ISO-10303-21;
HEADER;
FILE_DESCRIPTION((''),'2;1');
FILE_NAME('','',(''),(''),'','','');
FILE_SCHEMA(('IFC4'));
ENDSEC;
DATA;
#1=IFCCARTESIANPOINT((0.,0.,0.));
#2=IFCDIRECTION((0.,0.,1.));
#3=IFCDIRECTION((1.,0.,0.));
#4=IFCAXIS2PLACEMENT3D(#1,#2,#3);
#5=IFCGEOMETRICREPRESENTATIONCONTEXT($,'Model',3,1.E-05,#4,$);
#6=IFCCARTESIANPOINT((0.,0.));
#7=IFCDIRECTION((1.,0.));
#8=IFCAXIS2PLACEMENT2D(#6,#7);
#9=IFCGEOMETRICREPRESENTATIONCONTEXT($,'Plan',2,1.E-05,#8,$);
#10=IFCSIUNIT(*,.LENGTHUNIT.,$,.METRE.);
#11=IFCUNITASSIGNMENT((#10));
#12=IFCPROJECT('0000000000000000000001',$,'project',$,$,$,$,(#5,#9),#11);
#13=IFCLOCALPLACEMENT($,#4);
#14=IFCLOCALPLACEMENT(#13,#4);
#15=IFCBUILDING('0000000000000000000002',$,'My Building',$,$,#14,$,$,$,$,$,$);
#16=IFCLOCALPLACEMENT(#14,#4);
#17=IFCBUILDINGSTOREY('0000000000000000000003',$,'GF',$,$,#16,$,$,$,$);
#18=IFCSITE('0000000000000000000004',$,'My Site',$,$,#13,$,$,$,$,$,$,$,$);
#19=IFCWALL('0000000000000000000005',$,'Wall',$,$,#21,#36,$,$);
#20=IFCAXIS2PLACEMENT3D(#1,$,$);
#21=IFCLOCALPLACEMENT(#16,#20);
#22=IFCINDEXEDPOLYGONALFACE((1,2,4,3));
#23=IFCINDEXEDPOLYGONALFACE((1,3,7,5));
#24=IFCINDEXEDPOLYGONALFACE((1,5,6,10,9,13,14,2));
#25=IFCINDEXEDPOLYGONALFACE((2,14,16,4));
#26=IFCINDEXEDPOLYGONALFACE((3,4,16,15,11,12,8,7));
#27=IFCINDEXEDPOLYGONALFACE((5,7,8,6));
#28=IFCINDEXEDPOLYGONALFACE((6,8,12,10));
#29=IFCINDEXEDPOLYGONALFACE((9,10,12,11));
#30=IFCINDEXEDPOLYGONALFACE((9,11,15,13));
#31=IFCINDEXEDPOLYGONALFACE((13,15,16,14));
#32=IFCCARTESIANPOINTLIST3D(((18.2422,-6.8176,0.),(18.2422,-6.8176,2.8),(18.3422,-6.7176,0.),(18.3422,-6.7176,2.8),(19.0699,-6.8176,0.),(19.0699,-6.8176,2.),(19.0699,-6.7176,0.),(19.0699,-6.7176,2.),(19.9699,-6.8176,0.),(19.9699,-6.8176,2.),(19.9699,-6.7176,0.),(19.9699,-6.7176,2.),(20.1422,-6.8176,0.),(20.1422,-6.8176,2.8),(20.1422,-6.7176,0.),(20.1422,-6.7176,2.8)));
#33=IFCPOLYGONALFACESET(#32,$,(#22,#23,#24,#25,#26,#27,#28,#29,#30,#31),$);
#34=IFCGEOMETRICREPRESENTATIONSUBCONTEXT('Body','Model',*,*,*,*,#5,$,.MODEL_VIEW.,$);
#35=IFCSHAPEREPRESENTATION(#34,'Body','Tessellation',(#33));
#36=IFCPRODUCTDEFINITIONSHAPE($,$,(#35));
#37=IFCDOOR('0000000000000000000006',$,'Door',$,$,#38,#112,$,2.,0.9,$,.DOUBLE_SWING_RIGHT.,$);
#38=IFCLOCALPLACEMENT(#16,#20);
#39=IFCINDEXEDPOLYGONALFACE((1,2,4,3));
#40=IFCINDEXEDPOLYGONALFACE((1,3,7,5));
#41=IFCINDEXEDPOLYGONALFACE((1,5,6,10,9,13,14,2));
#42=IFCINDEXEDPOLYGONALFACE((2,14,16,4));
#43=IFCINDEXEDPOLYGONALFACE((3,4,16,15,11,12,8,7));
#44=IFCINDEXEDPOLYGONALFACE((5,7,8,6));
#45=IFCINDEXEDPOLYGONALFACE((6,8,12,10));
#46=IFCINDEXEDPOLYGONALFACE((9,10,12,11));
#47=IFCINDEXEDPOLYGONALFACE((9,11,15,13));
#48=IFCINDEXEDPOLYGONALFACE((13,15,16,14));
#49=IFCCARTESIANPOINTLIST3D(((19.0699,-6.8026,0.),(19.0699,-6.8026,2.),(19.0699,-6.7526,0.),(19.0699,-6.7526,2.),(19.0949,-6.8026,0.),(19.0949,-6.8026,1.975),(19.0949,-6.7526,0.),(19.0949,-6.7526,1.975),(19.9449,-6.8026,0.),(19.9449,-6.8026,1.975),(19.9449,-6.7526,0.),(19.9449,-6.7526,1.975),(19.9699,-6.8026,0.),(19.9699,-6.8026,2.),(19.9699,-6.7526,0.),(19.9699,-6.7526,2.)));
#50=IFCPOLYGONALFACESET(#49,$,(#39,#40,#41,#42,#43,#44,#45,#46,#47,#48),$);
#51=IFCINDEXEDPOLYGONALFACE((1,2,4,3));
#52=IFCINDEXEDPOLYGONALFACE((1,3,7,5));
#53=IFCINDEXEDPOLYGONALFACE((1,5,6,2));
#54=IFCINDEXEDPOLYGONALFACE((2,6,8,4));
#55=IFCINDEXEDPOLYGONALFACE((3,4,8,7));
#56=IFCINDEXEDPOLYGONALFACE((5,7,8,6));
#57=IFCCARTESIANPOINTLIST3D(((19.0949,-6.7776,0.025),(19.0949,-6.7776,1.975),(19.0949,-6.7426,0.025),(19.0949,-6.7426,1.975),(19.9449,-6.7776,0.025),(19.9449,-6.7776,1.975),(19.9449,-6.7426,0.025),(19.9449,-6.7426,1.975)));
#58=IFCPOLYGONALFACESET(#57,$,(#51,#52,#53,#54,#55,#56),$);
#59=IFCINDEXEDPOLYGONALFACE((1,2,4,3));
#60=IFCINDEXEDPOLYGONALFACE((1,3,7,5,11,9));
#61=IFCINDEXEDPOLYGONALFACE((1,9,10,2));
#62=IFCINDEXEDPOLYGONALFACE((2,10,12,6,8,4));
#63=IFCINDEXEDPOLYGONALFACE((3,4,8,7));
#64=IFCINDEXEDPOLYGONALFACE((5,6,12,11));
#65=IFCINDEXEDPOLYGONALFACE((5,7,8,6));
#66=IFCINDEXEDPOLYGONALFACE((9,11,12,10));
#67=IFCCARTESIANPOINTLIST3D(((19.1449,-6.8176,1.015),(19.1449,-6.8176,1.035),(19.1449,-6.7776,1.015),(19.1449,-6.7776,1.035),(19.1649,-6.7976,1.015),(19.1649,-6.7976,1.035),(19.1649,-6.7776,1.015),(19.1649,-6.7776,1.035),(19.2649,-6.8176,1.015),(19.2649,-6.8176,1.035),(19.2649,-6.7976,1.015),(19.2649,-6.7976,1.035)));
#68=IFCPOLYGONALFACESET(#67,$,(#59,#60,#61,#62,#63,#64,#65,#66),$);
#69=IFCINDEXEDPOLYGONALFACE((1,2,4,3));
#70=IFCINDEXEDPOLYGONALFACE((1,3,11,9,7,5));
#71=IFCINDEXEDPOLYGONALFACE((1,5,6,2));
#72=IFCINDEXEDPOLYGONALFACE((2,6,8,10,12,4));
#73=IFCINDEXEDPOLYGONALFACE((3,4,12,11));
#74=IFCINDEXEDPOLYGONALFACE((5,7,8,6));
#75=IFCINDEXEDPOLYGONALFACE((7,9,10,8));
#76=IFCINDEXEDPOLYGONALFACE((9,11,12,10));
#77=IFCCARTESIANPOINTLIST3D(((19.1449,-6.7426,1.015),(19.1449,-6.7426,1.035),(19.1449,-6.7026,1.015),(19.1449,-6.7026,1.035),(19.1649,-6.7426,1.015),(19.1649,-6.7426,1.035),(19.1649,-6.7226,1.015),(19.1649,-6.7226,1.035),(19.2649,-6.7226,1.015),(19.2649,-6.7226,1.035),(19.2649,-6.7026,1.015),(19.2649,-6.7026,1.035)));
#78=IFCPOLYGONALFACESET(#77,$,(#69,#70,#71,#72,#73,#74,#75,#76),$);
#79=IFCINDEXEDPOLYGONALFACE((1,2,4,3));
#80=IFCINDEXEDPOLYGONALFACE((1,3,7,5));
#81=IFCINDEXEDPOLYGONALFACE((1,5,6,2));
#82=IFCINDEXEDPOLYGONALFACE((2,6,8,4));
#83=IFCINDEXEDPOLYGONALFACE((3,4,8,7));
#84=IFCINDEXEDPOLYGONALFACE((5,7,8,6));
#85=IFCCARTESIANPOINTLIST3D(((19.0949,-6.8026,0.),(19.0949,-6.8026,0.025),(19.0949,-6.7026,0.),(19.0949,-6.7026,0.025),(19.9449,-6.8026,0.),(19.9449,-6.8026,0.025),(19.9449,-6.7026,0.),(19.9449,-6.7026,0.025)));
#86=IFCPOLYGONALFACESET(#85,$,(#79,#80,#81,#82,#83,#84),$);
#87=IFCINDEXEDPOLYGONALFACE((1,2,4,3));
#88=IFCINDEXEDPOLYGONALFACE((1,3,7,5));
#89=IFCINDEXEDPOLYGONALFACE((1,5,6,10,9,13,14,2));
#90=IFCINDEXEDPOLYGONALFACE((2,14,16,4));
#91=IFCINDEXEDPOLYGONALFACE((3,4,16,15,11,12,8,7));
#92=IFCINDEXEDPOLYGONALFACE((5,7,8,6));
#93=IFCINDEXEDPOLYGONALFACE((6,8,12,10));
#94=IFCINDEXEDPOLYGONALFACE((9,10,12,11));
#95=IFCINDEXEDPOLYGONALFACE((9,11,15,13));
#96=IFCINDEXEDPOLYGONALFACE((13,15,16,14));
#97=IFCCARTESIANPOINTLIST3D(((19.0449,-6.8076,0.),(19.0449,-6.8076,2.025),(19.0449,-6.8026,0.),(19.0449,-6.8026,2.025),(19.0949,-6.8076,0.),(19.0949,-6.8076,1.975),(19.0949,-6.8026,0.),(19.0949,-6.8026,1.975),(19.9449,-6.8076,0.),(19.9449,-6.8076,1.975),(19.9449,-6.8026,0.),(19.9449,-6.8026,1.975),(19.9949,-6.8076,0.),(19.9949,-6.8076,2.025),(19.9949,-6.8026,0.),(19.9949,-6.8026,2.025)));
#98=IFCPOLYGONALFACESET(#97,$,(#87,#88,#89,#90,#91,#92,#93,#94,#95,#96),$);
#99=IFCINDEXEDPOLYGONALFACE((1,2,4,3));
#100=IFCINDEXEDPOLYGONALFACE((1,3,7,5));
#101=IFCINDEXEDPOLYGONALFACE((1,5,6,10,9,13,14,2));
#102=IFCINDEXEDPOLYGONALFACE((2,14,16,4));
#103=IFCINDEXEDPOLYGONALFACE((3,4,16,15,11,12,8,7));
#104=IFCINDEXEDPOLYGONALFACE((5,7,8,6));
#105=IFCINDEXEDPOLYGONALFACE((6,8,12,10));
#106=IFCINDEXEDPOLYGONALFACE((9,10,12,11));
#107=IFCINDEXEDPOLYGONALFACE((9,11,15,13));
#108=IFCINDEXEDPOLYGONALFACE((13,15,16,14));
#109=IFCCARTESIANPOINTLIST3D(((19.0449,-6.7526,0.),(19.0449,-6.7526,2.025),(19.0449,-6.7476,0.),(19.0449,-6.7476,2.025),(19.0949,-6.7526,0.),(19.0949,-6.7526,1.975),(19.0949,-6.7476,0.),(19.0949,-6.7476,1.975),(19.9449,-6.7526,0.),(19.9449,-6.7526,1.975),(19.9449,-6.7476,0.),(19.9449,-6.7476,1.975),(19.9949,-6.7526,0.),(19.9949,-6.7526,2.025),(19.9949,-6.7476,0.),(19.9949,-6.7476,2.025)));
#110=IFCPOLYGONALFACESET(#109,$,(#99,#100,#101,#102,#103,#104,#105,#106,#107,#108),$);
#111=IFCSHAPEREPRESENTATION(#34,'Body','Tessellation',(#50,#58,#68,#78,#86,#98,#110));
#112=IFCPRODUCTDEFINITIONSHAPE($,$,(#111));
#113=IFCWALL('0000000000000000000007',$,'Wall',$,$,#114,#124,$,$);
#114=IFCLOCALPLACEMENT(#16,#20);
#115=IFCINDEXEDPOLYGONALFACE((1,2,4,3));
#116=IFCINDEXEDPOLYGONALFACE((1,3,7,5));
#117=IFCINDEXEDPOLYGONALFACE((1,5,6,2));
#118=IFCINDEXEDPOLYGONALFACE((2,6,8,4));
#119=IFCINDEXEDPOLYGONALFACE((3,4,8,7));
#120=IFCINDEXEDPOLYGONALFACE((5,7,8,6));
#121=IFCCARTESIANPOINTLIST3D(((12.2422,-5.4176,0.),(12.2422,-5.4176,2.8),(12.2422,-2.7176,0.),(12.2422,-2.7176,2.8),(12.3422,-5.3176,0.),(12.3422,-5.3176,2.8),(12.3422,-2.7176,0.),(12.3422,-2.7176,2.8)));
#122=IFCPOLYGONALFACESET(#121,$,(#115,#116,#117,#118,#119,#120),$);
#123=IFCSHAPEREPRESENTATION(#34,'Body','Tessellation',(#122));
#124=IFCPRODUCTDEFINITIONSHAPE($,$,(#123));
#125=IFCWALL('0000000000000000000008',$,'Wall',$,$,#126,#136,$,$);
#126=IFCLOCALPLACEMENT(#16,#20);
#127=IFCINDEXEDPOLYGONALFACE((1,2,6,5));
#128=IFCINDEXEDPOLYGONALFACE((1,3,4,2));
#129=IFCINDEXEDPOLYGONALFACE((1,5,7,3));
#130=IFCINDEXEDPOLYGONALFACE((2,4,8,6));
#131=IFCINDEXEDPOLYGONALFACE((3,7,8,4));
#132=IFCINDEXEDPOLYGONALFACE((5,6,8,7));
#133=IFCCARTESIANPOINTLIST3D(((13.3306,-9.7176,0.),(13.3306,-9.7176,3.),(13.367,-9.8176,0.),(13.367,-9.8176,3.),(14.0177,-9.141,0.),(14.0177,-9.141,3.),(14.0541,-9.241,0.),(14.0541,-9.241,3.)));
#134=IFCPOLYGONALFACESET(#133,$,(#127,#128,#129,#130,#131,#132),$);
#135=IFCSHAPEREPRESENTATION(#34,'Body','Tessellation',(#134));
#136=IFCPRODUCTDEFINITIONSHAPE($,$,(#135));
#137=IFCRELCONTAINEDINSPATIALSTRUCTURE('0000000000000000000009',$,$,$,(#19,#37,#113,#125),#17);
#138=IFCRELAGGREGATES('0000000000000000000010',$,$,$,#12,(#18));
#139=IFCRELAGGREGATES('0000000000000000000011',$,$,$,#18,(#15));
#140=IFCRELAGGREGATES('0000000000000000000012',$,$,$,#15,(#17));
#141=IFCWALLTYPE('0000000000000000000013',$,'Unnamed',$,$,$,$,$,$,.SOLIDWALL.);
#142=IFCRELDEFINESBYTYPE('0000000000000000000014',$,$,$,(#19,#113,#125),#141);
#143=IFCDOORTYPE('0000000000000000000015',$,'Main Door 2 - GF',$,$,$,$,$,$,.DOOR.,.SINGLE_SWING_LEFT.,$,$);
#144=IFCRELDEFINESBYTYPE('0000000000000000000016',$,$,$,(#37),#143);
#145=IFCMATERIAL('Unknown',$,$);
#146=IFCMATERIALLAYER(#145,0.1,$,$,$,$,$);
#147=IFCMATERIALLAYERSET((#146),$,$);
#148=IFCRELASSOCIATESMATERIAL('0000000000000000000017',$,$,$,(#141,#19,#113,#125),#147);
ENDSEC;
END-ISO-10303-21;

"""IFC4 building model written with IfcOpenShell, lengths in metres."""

from ifc_helpers import new_model, entity, si_unit, frame, origin_with_axes, origin_2d_with_axis, place, context, subcontext, project, spatial, line, indexed_curve, outline, extrude, shape, source, transform, mapped, material, layer, layer_set, layer_usage, type_object, type_shapes, element, fill, save


model = new_model("IFC4")

# Units and contexts
model_context = context("Model", 3, precision=1e-05, world=origin_with_axes())
plan_context = context("Plan", 2, precision=1e-05, world=origin_2d_with_axis())
body_context_1 = subcontext(model_context, "Body", "Model", "MODEL_VIEW")
body_context_2 = subcontext(plan_context, "Body", "Plan", "PLAN_VIEW")
ifc_project = project(units=[si_unit("LENGTHUNIT", "METRE")], contexts=[model_context, plan_context])

# Site, building, storey
site_placement = place(None, origin_with_axes())
site = spatial("IfcSite", under=ifc_project, at=site_placement, Name="My Site")
building_placement = place(site_placement, origin_with_axes())
building = spatial("IfcBuilding", under=site, at=building_placement, Name="My Building")
storey_placement = place(building_placement, origin_with_axes())
storey = spatial("IfcBuildingStorey", under=building, at=storey_placement, Name="GF")

# Shared definitions
ifc_material = material(Name="Unknown")

# Shared definitions
ifc_layer_1 = layer(ifc_material, 0.1)
ifc_layer_set_1 = layer_set([ifc_layer_1])
wall_type = type_object("IfcWallType", Name="Unnamed", PredefinedType="SOLIDWALL", material=ifc_layer_set_1)

# Wall, opening, door
shared_shape_1 = source(origin_with_axes(), body_context_1, "Body", "SweptSolid", [
    extrude(outline(indexed_curve([(0.0, 0.0), (0.9, 0.0), (0.9, 2.0), (0.0, 2.0)], segments=[line(1, 2, 3, 4, 1)])), frame((0.0, -0.6, 0.0), z_axis=(0.0, -1.0, 0.0), x_axis=(1.0, 0.0, 0.0)), (0.0, 0.0, -1.0), 1.2),
])
door_type_1 = type_object("IfcDoorType", Name="Main Door 2 - GF", OperationType="SINGLE_SWING_LEFT", PredefinedType="DOOR")
shared_shape_2 = source(origin_with_axes(), body_context_1, "Body", "SweptSolid", [
    extrude(outline(indexed_curve([(0.0, 0.0), (0.0, 2.0), (0.9, 2.0), (0.9, 0.0), (0.875, 0.0), (0.875, 1.975), (0.025, 1.975), (0.025, 0.0)], segments=[line(1, 2, 3, 4, 5, 6, 7, 8, 1)])), frame((0.0, 0.0, 0.0), z_axis=(0.0, -1.0, 0.0), x_axis=(1.0, 0.0, 0.0)), (0.0, 0.0, -1.0), 0.05),
    extrude(outline(indexed_curve([(0.0, 0.0), (0.85, 0.0), (0.85, 0.035), (0.0, 0.035)], segments=[line(1, 2, 3, 4, 1)])), frame((0.025, 0.025, 0.025), z_axis=(0.0, 0.0, 1.0), x_axis=(1.0, 0.0, 0.0)), (0.0, 0.0, 1.0), 1.95),
    extrude(outline(indexed_curve([(0.0, 0.0), (0.0, -0.04), (0.12, -0.04), (0.12, -0.02), (0.02, -0.02), (0.02, 0.0)], segments=[line(1, 2, 3, 4, 5, 6, 1)])), frame((0.075, 0.025, 1.015), z_axis=(0.0, 0.0, 1.0), x_axis=(1.0, 0.0, 0.0)), (0.0, 0.0, 1.0), 0.02),
    extrude(outline(indexed_curve([(0.0, 0.0), (0.0, 0.04), (0.12, 0.04), (0.12, 0.02), (0.02, 0.02), (0.02, 0.0)], segments=[line(1, 2, 3, 4, 5, 6, 1)])), frame((0.075, 0.06, 1.015), z_axis=(0.0, 0.0, 1.0), x_axis=(1.0, 0.0, 0.0)), (0.0, 0.0, 1.0), 0.02),
    extrude(outline(indexed_curve([(0.0, 0.0), (0.85, 0.0), (0.85, 0.1), (0.0, 0.1)], segments=[line(1, 2, 3, 4, 1)])), frame((0.025, 0.0, 0.0), z_axis=(0.0, 0.0, 1.0), x_axis=(1.0, 0.0, 0.0)), (0.0, 0.0, 1.0), 0.025),
    extrude(outline(indexed_curve([(0.0, 0.0), (0.0, 2.025), (0.95, 2.025), (0.95, 0.0), (0.9, 0.0), (0.9, 1.975), (0.05, 1.975), (0.05, 0.0)], segments=[line(1, 2, 3, 4, 5, 6, 7, 8, 1)])), frame((-0.025, -0.005, 0.0), z_axis=(0.0, -1.0, 0.0), x_axis=(1.0, 0.0, 0.0)), (0.0, 0.0, -1.0), 0.005),
    extrude(outline(indexed_curve([(0.0, 0.0), (0.0, 2.025), (0.95, 2.025), (0.95, 0.0), (0.9, 0.0), (0.9, 1.975), (0.05, 1.975), (0.05, 0.0)], segments=[line(1, 2, 3, 4, 5, 6, 7, 8, 1)])), frame((-0.025, 0.05, 0.0), z_axis=(0.0, -1.0, 0.0), x_axis=(1.0, 0.0, 0.0)), (0.0, 0.0, -1.0), 0.005),
])
shared_shape_3 = source(origin_with_axes(), body_context_2, "Body", "Curve2D", [
    entity("IfcIndexedPolyCurve", entity("IfcCartesianPointList2D", [[0.0, 0.0], [0.025, 0.0], [0.025, 0.05], [0.0, 0.05]]), [entity("IfcLineIndex", [1, 2, 3, 4, 1])]),
    entity("IfcIndexedPolyCurve", entity("IfcCartesianPointList2D", [[0.9, 0.0], [0.875, 0.0], [0.875, 0.05], [0.9, 0.05]]), [entity("IfcLineIndex", [1, 2, 3, 4, 1])]),
    entity("IfcIndexedPolyCurve", entity("IfcCartesianPointList2D", [[0.875, 0.05], [0.875, -0.8], [0.84, -0.8]])),
    entity("IfcTrimmedCurve", entity("IfcEllipse", entity("IfcAxis2Placement2D", entity("IfcCartesianPoint", [0.84, 0.05]), entity("IfcDirection", [1.0, 0.0])), 0.815, 0.85), [entity("IfcCartesianPoint", [0.84, 0.9])], [entity("IfcCartesianPoint", [0.84, -0.8])], True, "CARTESIAN"),
    entity("IfcIndexedPolyCurve", entity("IfcCartesianPointList2D", [[0.875, 0.05], [0.84, 0.05], [0.84, 0.9], [0.875, 0.9]]), [entity("IfcLineIndex", [1, 2, 3, 4, 1])]),
])
type_shapes(door_type_1, [shared_shape_2, shared_shape_3])
ifc_layer_usage_1 = layer_usage(ifc_layer_set_1, "AXIS2", "POSITIVE", 0.0)
wall_1_placement = place(storey_placement, frame((18.2422, -6.8176, 0.0), z_axis=(0.0, 0.0, 1.0), x_axis=(1.0, 0.0, 0.0)))
wall_1 = element("IfcWall", 1, at=wall_1_placement, inside=storey, type_object=wall_type, material=ifc_layer_usage_1, Name="Wall", context=body_context_1, shape_type="SweptSolid", body=[
    extrude(outline(indexed_curve([(0.0, 0.0), (0.1, 0.1), (1.9, 0.1), (1.9, 0.0)], segments=[line(1, 2, 3, 4, 1)])), origin_with_axes(), (0.0, 0.0, 1.0), 2.8),
])
opening_1_placement = place(wall_1_placement, frame((0.8277, 0.015, 0.0), z_axis=(0.0, 0.0, 1.0), x_axis=(1.0, 0.0, 0.0)))
opening_1 = element("IfcOpeningElement", 2, at=opening_1_placement, cuts=wall_1, PredefinedType="OPENING", context=body_context_1, shape_type="MappedRepresentation", body=[
    mapped(shared_shape_1, transform((0.0, 0.0, 0.0), x_axis=(1.0, 0.0, 0.0), y_axis=(0.0, 1.0, 0.0), z_axis=(0.0, 0.0, 1.0), scale=1.0)),
])
door_1_placement = place(opening_1_placement, frame((0.0, 0.0, 0.0), z_axis=(0.0, 0.0, 1.0), x_axis=(1.0, 0.0, 0.0)))
door_1 = element("IfcDoor", 3, at=door_1_placement, inside=storey, type_object=door_type_1, Name="Door", OperationType="DOUBLE_SWING_RIGHT", OverallHeight=2.0, OverallWidth=0.9, shapes=[
    shape(body_context_1, "Body", "MappedRepresentation", [mapped(shared_shape_2, transform((0.0, 0.0, 0.0), x_axis=(1.0, 0.0, 0.0), y_axis=(0.0, 1.0, 0.0), z_axis=(0.0, 0.0, 1.0), scale=1.0))]),
    shape(body_context_2, "Body", "MappedRepresentation", [mapped(shared_shape_3, transform((0.0, 0.0, 0.0), x_axis=(1.0, 0.0, 0.0), y_axis=(0.0, 1.0, 0.0), z_axis=(0.0, 0.0, 1.0), scale=1.0))]),
])
fill(opening_1, door_1)

# Walls
ifc_layer_usage_2 = layer_usage(ifc_layer_set_1, "AXIS2", "POSITIVE", 0.0)
wall_2_placement = place(storey_placement, frame((12.2422, -2.7176, 0.0), z_axis=(0.0, 0.0, 1.0), x_axis=(0.0, -1.0, 0.0)))
element("IfcWall", 4, at=wall_2_placement, inside=storey, type_object=wall_type, material=ifc_layer_usage_2, Name="Wall", context=body_context_1, shape_type="SweptSolid", body=[
    extrude(outline(indexed_curve([(0.0, 0.0), (0.0, 0.1), (2.6, 0.1), (2.7, 0.0)], segments=[line(1, 2, 3, 4, 1)])), origin_with_axes(), (0.0, 0.0, 1.0), 2.8),
])
ifc_layer_usage_3 = layer_usage(ifc_layer_set_1, "AXIS2", "POSITIVE", 0.0)
wall_3_placement = place(storey_placement, frame((14.0177, -9.141, 0.0), z_axis=(0.0, 0.0, 1.0), x_axis=(-0.766044, -0.642788, 0.0)))
element("IfcWall", 5, at=wall_3_placement, inside=storey, type_object=wall_type, material=ifc_layer_usage_3, Name="Wall", context=body_context_1, shape_type="SweptSolid", body=[
    extrude(outline(indexed_curve([(0.0, 0.0), (0.0364, 0.1), (0.9334, 0.1), (0.897, 0.0)], segments=[line(1, 2, 3, 4, 1)])), origin_with_axes(), (0.0, 0.0, 1.0), 3.0),
])

save(model, "model.ifc")
